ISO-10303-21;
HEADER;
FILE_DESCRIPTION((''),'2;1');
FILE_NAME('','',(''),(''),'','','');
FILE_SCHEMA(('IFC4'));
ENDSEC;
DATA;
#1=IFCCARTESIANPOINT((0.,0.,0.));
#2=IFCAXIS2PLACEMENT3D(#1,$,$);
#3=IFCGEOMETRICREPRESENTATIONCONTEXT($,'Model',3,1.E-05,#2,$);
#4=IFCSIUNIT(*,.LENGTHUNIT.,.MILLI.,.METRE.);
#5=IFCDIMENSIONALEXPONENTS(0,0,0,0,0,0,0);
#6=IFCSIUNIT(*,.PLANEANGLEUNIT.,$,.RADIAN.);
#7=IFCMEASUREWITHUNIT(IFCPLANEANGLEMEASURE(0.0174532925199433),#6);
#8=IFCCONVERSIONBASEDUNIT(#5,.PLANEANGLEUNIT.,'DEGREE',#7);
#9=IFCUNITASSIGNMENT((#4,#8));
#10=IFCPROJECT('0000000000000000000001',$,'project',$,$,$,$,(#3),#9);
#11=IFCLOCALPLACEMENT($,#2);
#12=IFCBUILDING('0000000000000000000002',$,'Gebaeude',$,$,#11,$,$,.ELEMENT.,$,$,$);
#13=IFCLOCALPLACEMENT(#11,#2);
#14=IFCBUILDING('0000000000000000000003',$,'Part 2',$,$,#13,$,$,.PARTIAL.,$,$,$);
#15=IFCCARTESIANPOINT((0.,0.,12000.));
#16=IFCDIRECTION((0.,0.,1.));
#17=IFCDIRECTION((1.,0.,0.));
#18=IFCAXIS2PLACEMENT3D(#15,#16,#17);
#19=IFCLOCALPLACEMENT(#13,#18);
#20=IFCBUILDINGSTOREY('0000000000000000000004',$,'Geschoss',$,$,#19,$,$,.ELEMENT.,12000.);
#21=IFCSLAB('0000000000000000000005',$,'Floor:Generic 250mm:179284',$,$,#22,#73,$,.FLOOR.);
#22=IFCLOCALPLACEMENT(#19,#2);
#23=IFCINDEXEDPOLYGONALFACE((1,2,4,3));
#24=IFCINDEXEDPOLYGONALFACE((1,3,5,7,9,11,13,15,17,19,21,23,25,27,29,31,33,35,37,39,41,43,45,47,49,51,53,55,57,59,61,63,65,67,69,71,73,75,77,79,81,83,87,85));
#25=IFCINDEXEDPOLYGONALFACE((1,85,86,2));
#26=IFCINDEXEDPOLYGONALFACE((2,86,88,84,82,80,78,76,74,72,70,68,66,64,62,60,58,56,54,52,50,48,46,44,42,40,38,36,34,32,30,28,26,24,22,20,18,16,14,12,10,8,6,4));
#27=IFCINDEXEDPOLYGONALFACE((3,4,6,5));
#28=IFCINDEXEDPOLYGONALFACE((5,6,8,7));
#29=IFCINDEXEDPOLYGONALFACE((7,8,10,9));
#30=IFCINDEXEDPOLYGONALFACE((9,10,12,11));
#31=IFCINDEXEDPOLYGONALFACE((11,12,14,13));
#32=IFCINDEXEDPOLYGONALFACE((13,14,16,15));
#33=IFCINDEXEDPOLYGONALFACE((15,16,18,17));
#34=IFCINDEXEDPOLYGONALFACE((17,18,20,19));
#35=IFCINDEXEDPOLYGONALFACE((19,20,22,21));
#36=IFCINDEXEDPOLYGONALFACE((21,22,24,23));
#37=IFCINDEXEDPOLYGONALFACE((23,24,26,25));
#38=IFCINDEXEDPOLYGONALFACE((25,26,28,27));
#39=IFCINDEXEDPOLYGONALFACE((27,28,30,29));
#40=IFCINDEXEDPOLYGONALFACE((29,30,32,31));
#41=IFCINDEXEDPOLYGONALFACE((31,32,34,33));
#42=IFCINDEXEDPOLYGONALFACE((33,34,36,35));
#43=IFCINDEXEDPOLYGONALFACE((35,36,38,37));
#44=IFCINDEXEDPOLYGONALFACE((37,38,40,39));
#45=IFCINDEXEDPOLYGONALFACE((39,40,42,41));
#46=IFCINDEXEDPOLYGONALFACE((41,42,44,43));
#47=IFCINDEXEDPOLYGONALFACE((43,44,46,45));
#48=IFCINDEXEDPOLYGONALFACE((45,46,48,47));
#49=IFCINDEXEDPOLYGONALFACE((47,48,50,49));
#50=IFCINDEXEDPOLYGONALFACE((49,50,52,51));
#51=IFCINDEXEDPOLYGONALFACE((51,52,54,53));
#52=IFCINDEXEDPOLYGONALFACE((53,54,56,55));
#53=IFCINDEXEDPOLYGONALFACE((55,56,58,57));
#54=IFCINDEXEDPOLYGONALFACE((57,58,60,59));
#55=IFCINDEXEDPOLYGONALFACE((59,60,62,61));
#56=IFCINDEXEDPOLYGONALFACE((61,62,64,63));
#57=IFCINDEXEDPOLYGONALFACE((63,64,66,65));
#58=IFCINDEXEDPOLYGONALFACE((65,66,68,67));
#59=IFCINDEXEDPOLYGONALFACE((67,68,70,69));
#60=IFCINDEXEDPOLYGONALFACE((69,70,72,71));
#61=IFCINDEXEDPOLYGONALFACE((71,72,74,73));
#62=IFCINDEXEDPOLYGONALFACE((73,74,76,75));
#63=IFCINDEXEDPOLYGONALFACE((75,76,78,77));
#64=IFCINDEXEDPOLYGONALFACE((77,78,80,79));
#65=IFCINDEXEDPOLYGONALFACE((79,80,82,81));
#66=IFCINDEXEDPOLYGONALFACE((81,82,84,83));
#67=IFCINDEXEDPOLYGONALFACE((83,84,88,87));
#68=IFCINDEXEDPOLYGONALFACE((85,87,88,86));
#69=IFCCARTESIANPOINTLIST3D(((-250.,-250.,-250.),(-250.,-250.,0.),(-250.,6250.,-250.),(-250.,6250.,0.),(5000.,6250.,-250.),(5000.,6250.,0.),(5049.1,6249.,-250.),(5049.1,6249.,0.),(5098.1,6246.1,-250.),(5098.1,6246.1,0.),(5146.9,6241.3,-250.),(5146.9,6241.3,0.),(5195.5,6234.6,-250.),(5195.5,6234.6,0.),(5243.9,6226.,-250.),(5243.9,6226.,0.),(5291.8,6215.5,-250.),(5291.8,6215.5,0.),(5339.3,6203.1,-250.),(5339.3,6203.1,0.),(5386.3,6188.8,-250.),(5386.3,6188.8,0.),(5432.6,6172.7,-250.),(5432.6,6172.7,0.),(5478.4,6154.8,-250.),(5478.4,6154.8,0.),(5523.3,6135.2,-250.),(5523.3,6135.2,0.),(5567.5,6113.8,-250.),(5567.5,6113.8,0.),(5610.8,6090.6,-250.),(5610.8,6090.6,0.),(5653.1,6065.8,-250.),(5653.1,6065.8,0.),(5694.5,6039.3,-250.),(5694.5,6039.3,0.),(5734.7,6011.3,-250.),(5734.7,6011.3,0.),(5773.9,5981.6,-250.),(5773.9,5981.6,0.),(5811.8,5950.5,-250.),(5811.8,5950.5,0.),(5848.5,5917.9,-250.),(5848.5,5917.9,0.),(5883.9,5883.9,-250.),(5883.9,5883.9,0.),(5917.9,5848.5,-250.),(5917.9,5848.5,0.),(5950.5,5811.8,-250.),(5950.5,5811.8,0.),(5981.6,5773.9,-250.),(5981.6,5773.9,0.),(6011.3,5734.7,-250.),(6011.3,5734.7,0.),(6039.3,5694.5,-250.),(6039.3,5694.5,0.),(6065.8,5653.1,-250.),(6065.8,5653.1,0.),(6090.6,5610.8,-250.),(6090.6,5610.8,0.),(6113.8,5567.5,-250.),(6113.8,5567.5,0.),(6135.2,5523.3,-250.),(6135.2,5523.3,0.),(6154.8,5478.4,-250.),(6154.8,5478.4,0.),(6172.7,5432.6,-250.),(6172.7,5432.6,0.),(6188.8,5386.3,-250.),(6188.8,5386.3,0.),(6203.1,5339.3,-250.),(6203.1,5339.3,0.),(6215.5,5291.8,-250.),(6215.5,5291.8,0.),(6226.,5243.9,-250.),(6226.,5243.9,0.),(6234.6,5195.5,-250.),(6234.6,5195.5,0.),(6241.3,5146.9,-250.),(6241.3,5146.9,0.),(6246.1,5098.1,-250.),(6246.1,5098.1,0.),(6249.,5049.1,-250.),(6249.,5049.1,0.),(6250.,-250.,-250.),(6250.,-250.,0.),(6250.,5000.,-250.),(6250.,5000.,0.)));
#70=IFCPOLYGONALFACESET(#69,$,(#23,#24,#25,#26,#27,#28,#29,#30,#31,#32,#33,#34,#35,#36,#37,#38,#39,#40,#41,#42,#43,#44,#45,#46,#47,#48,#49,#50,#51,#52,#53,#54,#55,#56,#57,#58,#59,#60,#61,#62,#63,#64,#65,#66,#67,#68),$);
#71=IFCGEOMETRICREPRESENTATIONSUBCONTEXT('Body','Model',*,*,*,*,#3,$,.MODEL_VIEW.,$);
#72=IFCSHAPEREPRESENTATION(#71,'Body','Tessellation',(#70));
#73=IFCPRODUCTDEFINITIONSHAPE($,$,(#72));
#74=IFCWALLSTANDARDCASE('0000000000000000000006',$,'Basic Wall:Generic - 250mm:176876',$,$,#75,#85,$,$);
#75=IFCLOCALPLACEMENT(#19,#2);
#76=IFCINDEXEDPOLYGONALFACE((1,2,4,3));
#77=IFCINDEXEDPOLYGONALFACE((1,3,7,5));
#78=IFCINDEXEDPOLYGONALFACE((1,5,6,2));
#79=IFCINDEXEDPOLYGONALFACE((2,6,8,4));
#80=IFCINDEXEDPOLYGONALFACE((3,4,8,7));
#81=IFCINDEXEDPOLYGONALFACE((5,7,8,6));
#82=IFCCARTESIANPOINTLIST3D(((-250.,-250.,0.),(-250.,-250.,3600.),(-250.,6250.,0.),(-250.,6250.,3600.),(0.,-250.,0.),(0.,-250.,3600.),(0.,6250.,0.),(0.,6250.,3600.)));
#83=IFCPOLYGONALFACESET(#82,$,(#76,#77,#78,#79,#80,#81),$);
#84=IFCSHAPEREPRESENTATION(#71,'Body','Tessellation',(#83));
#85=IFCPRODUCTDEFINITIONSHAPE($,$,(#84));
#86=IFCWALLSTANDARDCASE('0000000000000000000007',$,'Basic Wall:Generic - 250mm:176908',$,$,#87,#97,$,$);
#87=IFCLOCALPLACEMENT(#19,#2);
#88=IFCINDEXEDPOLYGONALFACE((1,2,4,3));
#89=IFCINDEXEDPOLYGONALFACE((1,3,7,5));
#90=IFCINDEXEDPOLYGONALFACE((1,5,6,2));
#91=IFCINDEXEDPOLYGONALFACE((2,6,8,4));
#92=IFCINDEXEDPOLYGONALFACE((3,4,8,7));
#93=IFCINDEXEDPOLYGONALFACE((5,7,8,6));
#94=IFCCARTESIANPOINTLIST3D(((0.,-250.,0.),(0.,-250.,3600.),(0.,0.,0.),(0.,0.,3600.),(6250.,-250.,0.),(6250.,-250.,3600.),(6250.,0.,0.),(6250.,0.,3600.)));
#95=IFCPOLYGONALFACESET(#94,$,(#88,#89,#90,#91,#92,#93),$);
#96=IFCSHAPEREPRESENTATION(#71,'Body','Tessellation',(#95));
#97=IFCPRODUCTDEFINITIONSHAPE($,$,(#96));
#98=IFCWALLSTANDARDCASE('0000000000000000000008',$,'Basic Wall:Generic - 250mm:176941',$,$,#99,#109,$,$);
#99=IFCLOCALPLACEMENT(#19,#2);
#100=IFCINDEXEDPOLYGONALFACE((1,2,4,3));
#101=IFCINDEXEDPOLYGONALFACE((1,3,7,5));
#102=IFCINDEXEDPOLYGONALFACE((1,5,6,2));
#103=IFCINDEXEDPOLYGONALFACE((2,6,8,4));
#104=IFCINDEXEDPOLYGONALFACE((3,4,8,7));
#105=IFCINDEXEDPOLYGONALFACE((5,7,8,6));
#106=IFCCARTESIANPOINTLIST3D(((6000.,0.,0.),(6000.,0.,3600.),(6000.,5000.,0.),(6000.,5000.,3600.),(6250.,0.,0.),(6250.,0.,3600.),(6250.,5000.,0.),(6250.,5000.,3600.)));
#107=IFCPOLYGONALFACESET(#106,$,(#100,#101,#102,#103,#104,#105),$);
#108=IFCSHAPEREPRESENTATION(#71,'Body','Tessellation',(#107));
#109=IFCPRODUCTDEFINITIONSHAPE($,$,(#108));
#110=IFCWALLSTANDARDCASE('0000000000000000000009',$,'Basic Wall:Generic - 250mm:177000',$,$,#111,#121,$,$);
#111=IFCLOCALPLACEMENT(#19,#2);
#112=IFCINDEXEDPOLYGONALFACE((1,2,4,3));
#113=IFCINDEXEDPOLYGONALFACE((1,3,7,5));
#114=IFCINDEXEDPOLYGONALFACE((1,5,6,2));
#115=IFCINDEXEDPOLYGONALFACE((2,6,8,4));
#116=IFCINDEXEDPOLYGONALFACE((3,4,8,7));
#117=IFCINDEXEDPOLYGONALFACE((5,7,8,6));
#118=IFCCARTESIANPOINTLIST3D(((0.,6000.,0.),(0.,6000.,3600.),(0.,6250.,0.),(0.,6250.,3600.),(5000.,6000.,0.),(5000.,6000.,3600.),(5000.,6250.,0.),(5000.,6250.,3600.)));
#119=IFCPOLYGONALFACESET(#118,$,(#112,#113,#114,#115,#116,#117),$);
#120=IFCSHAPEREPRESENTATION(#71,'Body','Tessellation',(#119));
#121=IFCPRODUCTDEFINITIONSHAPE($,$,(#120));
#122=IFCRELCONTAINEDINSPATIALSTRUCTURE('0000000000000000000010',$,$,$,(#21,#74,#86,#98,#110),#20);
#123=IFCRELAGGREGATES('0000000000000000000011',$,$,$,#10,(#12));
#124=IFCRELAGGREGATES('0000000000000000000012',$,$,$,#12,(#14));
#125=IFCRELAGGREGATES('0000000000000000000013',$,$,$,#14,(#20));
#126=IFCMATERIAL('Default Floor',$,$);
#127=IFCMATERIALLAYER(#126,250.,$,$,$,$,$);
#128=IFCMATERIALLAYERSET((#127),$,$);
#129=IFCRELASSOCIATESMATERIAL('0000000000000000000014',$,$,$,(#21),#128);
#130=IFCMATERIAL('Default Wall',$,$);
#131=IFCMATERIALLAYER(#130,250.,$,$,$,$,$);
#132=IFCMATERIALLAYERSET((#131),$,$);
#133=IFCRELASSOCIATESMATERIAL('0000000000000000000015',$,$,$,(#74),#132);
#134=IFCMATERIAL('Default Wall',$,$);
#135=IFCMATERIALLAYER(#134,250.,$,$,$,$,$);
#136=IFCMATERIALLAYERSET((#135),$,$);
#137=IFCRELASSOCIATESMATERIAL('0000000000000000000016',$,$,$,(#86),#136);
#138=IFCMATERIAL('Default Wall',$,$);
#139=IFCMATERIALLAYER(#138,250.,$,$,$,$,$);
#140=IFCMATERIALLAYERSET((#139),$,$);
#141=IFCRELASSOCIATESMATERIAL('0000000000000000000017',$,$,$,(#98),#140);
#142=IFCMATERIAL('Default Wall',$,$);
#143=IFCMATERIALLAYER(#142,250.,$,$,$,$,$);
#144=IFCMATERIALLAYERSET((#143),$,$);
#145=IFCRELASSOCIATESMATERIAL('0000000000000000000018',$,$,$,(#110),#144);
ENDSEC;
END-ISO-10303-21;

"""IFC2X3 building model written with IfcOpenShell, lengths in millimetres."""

from ifc_helpers import new_model, entity, si_unit, converted_unit, frame, frame_2d, origin, origin_with_axes, place, context, subcontext, project, spatial, polyline, rectangle, outline, extrude, material, layer, layer_set, layer_usage, element, save


model = new_model("IFC2X3")

# Units and contexts
model_context = context("Model", 3, precision=1e-05, world=origin())
body_context = subcontext(model_context, "Body", "Model", "MODEL_VIEW")
ifc_project = project(units=[si_unit("LENGTHUNIT", "METRE", prefix="MILLI"), converted_unit("PLANEANGLEUNIT", "DEGREE", entity("IfcPlaneAngleMeasure", 0.0174532925199433), si_unit("PLANEANGLEUNIT", "RADIAN"), dimensions=[0, 0, 0, 0, 0, 0, 0])], contexts=[model_context])

# Buildings, storey
building_1_placement = place(None, origin())
building_1 = spatial("IfcBuilding", under=ifc_project, at=building_1_placement, Name="Gebaeude", CompositionType="ELEMENT")
building_2_placement = place(building_1_placement, origin())
building_2 = spatial("IfcBuilding", under=building_1, at=building_2_placement, Name="Part 2", CompositionType="PARTIAL")
storey_placement = place(building_2_placement, frame((0.0, 0.0, 12000.0), z_axis=(0.0, 0.0, 1.0), x_axis=(1.0, 0.0, 0.0)))
storey = spatial("IfcBuildingStorey", under=building_2, at=storey_placement, Name="Geschoss", CompositionType="ELEMENT", Elevation=12000.0)

# Slab
ifc_material_1 = material(Name="Default Floor")
ifc_layer_1 = layer(ifc_material_1, 250.0)
ifc_layer_set_1 = layer_set([ifc_layer_1])
ifc_layer_usage_1 = layer_usage(ifc_layer_set_1, "AXIS3", "POSITIVE", 0.0)
slab_placement = place(storey_placement, frame((-250.0, -250.0, -250.0), z_axis=(0.0, 0.0, 1.0), x_axis=(1.0, 0.0, 0.0)))
element("IfcSlab", 1, at=slab_placement, inside=storey, material=ifc_layer_usage_1, Name="Floor:Generic 250mm:179284", PredefinedType="FLOOR", context=body_context, shape_type="SweptSolid", body=[
    extrude(outline(polyline([(0.0, 6500.0), (0.0, 0.0), (6500.0, 0.0), (6500.0, 5250.0), (6499.0, 5299.1), (6496.1, 5348.1), (6491.3, 5396.9), (6484.6, 5445.5), (6476.0, 5493.9), (6465.5, 5541.8), (6453.1, 5589.3), (6438.8, 5636.3), (6422.7, 5682.6), (6404.8, 5728.4), (6385.2, 5773.3), (6363.8, 5817.5), (6340.6, 5860.8), (6315.8, 5903.1), (6289.3, 5944.5), (6261.3, 5984.7), (6231.6, 6023.9), (6200.5, 6061.8), (6167.9, 6098.5), (6133.9, 6133.9), (6098.5, 6167.9), (6061.8, 6200.5), (6023.9, 6231.6), (5984.7, 6261.3), (5944.5, 6289.3), (5903.1, 6315.8), (5860.8, 6340.6), (5817.5, 6363.8), (5773.3, 6385.2), (5728.4, 6404.8), (5682.6, 6422.7), (5636.3, 6438.8), (5589.3, 6453.1), (5541.8, 6465.5), (5493.9, 6476.0), (5445.5, 6484.6), (5396.9, 6491.3), (5348.1, 6496.1), (5299.1, 6499.0), (5250.0, 6500.0), (0.0, 6500.0)])), origin_with_axes(), (0.0, 0.0, 1.0), 250.0),
])

# Walls
ifc_material_2 = material(Name="Default Wall")
ifc_layer_2 = layer(ifc_material_2, 250.0)
ifc_layer_set_2 = layer_set([ifc_layer_2])
ifc_layer_usage_2 = layer_usage(ifc_layer_set_2, "AXIS2", "POSITIVE", -125.0)
wall_1_placement = place(storey_placement, frame((-250.0, 6250.0, 0.0), z_axis=(0.0, 0.0, 1.0), x_axis=(0.0, -1.0, 0.0)))
element("IfcWallStandardCase", 2, at=wall_1_placement, inside=storey, material=ifc_layer_usage_2, Name="Basic Wall:Generic - 250mm:176876", context=body_context, shape_type="SweptSolid", body=[
    extrude(rectangle(XDim=6500.0, YDim=250.0, at=frame_2d((3250.0, 125.0), x_axis=(1.0, 0.0))), origin_with_axes(), (0.0, 0.0, 1.0), 3600.0),
])
ifc_material_3 = material(Name="Default Wall")
ifc_layer_3 = layer(ifc_material_3, 250.0)
ifc_layer_set_3 = layer_set([ifc_layer_3])
ifc_layer_usage_3 = layer_usage(ifc_layer_set_3, "AXIS2", "POSITIVE", -125.0)
wall_2_placement = place(storey_placement, frame((0.0, -250.0, 0.0), z_axis=(0.0, 0.0, 1.0), x_axis=(1.0, 0.0, 0.0)))
element("IfcWallStandardCase", 3, at=wall_2_placement, inside=storey, material=ifc_layer_usage_3, Name="Basic Wall:Generic - 250mm:176908", context=body_context, shape_type="SweptSolid", body=[
    extrude(rectangle(XDim=6250.0, YDim=250.0, at=frame_2d((3125.0, 125.0), x_axis=(1.0, 0.0))), origin_with_axes(), (0.0, 0.0, 1.0), 3600.0),
])
ifc_material_4 = material(Name="Default Wall")
ifc_layer_4 = layer(ifc_material_4, 250.0)
ifc_layer_set_4 = layer_set([ifc_layer_4])
ifc_layer_usage_4 = layer_usage(ifc_layer_set_4, "AXIS2", "POSITIVE", -125.0)
wall_3_placement = place(storey_placement, frame((6250.0, 0.0, 0.0), z_axis=(0.0, 0.0, 1.0), x_axis=(0.0, 1.0, 0.0)))
element("IfcWallStandardCase", 4, at=wall_3_placement, inside=storey, material=ifc_layer_usage_4, Name="Basic Wall:Generic - 250mm:176941", context=body_context, shape_type="SweptSolid", body=[
    extrude(rectangle(XDim=5000.0, YDim=250.0, at=frame_2d((2500.0, 125.0), x_axis=(1.0, 0.0))), origin_with_axes(), (0.0, 0.0, 1.0), 3600.0),
])
ifc_material_5 = material(Name="Default Wall")
ifc_layer_5 = layer(ifc_material_5, 250.0)
ifc_layer_set_5 = layer_set([ifc_layer_5])
ifc_layer_usage_5 = layer_usage(ifc_layer_set_5, "AXIS2", "POSITIVE", -125.0)
wall_4_placement = place(storey_placement, frame((0.0, 6000.0, 0.0), z_axis=(0.0, 0.0, 1.0), x_axis=(1.0, 0.0, 0.0)))
element("IfcWallStandardCase", 5, at=wall_4_placement, inside=storey, material=ifc_layer_usage_5, Name="Basic Wall:Generic - 250mm:177000", context=body_context, shape_type="SweptSolid", body=[
    extrude(rectangle(XDim=5000.0, YDim=250.0, at=frame_2d((2500.0, 125.0), x_axis=(1.0, 0.0))), origin_with_axes(), (0.0, 0.0, 1.0), 3600.0),
])

save(model, "model.ifc")
